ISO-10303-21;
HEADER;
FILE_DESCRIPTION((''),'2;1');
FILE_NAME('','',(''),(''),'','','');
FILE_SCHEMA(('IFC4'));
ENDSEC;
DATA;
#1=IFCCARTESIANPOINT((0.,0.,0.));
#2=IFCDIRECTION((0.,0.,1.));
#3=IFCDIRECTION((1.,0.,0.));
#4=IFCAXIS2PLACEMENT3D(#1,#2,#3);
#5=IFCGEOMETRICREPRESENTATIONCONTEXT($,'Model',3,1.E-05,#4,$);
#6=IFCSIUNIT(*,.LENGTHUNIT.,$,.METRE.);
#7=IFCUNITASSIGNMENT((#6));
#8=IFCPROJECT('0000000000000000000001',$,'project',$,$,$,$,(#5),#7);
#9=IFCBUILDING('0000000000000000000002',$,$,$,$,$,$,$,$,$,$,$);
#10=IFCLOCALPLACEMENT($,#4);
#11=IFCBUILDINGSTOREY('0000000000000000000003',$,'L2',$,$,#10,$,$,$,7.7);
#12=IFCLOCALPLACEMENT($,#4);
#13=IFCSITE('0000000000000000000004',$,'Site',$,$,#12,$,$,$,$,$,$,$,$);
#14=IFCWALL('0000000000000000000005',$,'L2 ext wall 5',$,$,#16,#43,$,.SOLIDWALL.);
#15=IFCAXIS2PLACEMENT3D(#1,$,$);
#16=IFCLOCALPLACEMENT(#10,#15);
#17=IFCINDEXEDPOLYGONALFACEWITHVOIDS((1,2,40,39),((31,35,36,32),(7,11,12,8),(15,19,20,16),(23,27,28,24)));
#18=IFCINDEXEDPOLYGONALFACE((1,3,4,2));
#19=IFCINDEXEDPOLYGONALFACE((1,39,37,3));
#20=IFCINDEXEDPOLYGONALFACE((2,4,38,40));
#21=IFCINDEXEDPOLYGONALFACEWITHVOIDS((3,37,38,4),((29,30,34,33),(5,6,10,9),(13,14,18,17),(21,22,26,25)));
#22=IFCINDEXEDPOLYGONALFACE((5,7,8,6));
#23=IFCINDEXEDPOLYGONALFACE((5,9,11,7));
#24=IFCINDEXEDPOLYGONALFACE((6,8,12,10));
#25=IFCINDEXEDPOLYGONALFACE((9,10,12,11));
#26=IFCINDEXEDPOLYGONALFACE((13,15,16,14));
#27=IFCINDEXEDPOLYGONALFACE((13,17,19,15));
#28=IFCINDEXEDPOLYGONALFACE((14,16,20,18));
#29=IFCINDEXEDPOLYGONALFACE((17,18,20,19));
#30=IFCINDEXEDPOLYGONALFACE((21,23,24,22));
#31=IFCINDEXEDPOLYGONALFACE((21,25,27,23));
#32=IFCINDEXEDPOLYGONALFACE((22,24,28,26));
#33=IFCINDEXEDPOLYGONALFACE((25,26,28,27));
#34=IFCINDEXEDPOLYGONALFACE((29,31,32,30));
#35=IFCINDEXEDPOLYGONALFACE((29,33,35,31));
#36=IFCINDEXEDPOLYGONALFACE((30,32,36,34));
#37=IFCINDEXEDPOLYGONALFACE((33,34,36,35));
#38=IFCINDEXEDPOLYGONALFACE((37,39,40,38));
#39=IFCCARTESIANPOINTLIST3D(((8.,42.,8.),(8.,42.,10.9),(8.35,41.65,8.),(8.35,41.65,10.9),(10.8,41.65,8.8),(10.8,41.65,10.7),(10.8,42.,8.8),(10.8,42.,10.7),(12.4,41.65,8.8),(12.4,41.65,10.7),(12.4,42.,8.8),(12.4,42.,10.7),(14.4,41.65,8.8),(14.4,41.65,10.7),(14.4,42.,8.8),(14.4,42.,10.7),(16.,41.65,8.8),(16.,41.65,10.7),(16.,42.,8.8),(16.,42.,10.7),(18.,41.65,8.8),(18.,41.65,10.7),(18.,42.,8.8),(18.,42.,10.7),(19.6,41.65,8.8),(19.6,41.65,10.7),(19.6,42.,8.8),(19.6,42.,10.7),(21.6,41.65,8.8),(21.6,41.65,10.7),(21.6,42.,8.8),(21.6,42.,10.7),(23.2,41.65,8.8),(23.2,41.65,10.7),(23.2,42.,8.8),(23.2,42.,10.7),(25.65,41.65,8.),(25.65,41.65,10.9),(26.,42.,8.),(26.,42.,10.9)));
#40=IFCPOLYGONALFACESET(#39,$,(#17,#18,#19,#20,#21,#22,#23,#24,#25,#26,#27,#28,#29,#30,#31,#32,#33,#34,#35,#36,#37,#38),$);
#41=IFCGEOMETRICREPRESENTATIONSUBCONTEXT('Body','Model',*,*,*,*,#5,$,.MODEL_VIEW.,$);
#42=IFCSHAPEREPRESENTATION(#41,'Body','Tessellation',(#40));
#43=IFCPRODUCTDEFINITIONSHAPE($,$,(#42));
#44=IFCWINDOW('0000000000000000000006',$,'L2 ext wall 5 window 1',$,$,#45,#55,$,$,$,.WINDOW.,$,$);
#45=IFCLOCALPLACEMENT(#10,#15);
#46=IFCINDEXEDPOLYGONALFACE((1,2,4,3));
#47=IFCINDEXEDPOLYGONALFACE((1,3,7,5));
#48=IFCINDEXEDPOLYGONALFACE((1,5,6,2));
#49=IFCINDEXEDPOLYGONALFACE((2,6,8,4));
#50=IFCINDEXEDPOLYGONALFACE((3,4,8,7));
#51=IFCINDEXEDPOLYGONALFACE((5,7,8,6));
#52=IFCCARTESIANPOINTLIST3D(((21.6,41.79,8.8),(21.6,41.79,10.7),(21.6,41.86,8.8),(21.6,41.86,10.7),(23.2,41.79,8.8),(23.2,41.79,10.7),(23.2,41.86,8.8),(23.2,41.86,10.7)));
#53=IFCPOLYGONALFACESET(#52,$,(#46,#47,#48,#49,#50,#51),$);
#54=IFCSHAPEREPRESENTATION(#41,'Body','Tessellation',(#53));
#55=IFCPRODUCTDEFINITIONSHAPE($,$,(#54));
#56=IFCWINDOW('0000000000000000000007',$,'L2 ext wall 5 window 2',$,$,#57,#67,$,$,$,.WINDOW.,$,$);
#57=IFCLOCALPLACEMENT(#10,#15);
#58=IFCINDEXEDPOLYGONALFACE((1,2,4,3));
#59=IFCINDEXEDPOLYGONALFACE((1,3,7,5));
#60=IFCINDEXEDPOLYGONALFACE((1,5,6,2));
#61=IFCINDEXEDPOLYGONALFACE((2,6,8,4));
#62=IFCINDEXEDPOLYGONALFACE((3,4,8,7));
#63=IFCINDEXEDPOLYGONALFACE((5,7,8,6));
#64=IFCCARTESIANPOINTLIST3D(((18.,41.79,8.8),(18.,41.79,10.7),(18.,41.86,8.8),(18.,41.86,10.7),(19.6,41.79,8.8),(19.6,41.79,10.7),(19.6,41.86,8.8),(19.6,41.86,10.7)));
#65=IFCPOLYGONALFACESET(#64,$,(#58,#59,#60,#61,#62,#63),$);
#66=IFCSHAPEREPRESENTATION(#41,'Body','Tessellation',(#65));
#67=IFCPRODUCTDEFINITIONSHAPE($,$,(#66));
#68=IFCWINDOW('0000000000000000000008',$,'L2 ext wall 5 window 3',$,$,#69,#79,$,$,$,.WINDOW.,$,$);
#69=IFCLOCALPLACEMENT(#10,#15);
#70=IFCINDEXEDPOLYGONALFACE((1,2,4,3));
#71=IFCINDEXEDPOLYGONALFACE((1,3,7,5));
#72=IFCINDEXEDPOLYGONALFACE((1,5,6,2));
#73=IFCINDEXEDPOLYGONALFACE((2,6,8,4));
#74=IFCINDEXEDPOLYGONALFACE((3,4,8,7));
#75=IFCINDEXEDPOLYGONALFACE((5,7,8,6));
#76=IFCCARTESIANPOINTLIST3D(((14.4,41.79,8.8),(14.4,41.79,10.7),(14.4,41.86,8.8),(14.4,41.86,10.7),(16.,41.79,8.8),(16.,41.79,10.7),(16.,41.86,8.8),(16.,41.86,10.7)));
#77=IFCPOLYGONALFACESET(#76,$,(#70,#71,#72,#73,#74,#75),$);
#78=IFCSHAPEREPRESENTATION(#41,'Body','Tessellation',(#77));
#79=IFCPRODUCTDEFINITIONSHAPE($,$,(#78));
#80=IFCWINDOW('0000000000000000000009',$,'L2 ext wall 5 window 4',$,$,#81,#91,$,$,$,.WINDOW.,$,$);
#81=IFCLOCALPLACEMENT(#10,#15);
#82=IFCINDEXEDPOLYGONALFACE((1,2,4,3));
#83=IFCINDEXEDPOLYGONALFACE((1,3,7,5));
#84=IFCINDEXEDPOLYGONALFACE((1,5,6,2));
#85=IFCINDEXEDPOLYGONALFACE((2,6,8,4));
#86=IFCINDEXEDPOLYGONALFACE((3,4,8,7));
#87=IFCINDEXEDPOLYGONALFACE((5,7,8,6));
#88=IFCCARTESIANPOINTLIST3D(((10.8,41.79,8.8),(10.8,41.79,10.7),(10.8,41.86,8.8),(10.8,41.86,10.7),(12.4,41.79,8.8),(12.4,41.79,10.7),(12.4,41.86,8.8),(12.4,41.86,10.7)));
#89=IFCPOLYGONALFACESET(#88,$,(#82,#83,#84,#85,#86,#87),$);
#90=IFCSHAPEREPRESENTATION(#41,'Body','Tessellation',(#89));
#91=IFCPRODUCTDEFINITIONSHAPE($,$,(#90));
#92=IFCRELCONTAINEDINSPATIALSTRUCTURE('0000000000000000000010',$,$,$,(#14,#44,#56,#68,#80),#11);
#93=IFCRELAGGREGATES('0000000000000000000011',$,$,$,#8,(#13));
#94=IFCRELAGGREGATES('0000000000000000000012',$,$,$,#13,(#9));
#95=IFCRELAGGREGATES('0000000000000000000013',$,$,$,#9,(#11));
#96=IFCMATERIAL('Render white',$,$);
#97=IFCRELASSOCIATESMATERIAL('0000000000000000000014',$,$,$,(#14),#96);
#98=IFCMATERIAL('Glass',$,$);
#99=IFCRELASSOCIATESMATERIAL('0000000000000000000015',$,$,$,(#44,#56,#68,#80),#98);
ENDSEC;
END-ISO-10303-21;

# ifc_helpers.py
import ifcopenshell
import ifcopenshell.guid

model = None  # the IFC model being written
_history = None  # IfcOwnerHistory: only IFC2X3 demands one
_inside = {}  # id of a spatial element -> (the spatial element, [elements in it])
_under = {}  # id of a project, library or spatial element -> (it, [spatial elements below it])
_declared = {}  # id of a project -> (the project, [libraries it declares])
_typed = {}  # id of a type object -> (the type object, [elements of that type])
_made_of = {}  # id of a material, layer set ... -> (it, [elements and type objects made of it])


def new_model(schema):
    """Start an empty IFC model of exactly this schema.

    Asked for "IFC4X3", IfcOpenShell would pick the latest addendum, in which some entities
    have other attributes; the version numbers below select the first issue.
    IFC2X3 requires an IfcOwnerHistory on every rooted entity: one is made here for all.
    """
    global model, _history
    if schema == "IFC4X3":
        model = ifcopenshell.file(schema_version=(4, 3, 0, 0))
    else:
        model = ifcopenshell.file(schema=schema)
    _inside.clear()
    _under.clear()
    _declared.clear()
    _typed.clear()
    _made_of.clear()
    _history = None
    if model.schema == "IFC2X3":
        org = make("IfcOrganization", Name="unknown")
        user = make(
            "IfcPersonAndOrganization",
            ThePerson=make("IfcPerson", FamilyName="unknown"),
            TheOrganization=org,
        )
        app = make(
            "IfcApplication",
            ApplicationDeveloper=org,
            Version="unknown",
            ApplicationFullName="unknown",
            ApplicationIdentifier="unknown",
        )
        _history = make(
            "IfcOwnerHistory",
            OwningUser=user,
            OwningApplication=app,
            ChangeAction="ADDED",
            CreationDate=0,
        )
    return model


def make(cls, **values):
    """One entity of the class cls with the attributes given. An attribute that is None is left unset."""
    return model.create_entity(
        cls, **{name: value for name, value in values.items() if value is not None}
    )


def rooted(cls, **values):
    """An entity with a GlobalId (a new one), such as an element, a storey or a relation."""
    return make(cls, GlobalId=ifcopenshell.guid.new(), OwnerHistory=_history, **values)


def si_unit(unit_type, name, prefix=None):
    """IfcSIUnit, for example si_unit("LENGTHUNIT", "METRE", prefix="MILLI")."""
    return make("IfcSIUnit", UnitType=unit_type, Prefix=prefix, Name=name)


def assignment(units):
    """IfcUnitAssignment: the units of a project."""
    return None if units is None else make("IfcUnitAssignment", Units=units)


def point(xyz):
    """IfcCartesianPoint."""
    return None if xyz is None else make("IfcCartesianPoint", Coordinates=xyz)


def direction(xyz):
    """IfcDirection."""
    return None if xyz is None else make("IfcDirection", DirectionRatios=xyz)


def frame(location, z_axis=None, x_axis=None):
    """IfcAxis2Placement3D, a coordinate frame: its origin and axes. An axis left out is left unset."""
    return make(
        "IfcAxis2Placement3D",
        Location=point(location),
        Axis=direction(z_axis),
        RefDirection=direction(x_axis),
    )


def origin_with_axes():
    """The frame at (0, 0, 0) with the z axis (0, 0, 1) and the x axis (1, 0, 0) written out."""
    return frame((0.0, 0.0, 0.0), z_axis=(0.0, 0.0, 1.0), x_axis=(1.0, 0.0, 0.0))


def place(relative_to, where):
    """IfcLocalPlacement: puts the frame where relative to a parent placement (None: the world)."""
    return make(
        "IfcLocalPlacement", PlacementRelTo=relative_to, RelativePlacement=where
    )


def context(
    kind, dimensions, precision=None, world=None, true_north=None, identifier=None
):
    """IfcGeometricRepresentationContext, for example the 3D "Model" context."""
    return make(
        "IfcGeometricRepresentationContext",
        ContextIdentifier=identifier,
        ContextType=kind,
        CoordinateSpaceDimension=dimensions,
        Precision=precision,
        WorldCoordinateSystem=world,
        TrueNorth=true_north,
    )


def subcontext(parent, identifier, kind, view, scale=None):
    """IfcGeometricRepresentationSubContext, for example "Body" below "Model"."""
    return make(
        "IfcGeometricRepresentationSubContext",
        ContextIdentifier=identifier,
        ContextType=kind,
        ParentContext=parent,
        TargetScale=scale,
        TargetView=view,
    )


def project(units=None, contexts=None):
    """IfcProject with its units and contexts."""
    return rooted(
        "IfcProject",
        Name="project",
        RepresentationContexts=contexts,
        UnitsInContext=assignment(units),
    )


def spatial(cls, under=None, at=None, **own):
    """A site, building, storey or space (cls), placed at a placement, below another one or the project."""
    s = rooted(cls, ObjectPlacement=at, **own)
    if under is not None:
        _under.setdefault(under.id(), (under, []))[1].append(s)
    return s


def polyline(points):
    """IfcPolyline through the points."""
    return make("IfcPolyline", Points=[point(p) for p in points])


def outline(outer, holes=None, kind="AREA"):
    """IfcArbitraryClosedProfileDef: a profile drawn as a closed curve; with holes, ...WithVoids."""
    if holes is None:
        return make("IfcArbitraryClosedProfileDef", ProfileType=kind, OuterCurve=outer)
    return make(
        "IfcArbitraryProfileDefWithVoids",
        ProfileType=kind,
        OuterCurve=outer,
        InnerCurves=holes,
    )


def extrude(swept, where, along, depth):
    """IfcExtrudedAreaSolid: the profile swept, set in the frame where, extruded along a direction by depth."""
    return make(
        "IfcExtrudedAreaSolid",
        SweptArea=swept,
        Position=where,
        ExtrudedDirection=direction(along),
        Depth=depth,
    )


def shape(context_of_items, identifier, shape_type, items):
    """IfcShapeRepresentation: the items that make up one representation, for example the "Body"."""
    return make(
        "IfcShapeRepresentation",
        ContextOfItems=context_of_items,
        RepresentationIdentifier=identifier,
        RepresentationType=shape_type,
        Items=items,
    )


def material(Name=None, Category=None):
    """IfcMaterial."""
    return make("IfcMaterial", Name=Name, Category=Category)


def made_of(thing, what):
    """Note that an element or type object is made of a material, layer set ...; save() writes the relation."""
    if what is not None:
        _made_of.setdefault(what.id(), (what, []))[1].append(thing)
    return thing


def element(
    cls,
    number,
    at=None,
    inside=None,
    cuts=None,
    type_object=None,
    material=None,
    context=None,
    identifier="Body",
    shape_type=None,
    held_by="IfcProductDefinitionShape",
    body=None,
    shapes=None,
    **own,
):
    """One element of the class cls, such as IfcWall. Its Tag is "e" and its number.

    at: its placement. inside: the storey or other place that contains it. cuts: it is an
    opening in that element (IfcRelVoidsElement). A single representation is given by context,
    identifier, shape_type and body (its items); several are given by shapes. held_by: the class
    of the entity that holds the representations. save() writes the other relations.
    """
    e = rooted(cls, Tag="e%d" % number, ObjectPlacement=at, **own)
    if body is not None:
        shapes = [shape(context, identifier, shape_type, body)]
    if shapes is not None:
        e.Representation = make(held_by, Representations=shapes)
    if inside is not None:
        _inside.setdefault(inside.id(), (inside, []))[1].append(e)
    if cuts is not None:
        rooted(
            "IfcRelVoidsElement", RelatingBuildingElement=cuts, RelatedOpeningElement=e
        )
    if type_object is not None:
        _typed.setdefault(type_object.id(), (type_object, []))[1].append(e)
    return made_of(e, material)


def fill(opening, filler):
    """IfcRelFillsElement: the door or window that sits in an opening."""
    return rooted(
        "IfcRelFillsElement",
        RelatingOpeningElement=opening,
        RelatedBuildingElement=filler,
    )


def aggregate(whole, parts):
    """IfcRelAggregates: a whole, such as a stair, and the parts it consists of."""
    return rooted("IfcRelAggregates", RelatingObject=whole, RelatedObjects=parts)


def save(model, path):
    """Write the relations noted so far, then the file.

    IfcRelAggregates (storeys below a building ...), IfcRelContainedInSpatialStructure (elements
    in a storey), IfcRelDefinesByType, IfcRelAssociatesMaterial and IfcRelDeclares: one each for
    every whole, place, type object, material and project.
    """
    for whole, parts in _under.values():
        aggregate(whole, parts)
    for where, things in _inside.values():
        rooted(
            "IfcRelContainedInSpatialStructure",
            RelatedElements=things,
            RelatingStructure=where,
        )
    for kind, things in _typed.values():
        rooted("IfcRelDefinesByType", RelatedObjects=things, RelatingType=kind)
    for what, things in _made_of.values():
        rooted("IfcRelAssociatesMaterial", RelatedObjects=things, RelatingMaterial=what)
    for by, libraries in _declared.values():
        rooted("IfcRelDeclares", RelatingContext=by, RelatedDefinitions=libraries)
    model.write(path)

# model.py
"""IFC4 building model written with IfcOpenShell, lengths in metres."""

from ifc_helpers import new_model, si_unit, frame, origin_with_axes, place, context, subcontext, project, spatial, polyline, outline, extrude, material, element, fill, save


model = new_model("IFC4")

# Units and contexts
model_context = context("Model", 3, precision=1e-05, world=origin_with_axes())
body_context = subcontext(model_context, "Body", "Model", "MODEL_VIEW")
ifc_project = project(units=[si_unit("LENGTHUNIT", "METRE")], contexts=[model_context])

# Site, building, storey
site_placement = place(None, origin_with_axes())
site = spatial("IfcSite", under=ifc_project, at=site_placement, Name="Site")
building = spatial("IfcBuilding", under=site)
storey_placement = place(None, origin_with_axes())
storey = spatial("IfcBuildingStorey", under=building, at=storey_placement, Name="L2", Elevation=7.7)

# Wall, openings, windows
ifc_material_1 = material(Name="Render white")
wall_1_placement = place(storey_placement, origin_with_axes())
wall_1 = element("IfcWall", 1, at=wall_1_placement, inside=storey, material=ifc_material_1, Name="L2 ext wall 5", PredefinedType="SOLIDWALL", context=body_context, shape_type="SweptSolid", body=[
    extrude(outline(polyline([(26.0, 42.0), (8.0, 42.0), (8.35, 41.65), (25.65, 41.65), (26.0, 42.0)])), frame((0.0, 0.0, 8.0), z_axis=(0.0, 0.0, 1.0), x_axis=(1.0, 0.0, 0.0)), (0.0, 0.0, 1.0), 2.9),
])
opening_1_placement = place(wall_1_placement, origin_with_axes())
opening_1 = element("IfcOpeningElement", 2, at=opening_1_placement, cuts=wall_1, context=body_context, shape_type="SweptSolid", body=[
    extrude(outline(polyline([(23.2, 42.05), (21.6, 42.05), (21.6, 41.6), (23.2, 41.6), (23.2, 42.05)])), frame((0.0, 0.0, 8.8), z_axis=(0.0, 0.0, 1.0), x_axis=(1.0, 0.0, 0.0)), (0.0, 0.0, 1.0), 1.9),
])
opening_2_placement = place(wall_1_placement, origin_with_axes())
opening_2 = element("IfcOpeningElement", 3, at=opening_2_placement, cuts=wall_1, context=body_context, shape_type="SweptSolid", body=[
    extrude(outline(polyline([(19.6, 42.05), (18.0, 42.05), (18.0, 41.6), (19.6, 41.6), (19.6, 42.05)])), frame((0.0, 0.0, 8.8), z_axis=(0.0, 0.0, 1.0), x_axis=(1.0, 0.0, 0.0)), (0.0, 0.0, 1.0), 1.9),
])
opening_3_placement = place(wall_1_placement, origin_with_axes())
opening_3 = element("IfcOpeningElement", 4, at=opening_3_placement, cuts=wall_1, context=body_context, shape_type="SweptSolid", body=[
    extrude(outline(polyline([(16.0, 42.05), (14.4, 42.05), (14.4, 41.6), (16.0, 41.6), (16.0, 42.05)])), frame((0.0, 0.0, 8.8), z_axis=(0.0, 0.0, 1.0), x_axis=(1.0, 0.0, 0.0)), (0.0, 0.0, 1.0), 1.9),
])
opening_4_placement = place(wall_1_placement, origin_with_axes())
opening_4 = element("IfcOpeningElement", 5, at=opening_4_placement, cuts=wall_1, context=body_context, shape_type="SweptSolid", body=[
    extrude(outline(polyline([(12.4, 42.05), (10.8, 42.05), (10.8, 41.6), (12.4, 41.6), (12.4, 42.05)])), frame((0.0, 0.0, 8.8), z_axis=(0.0, 0.0, 1.0), x_axis=(1.0, 0.0, 0.0)), (0.0, 0.0, 1.0), 1.9),
])
ifc_material_2 = material(Name="Glass")
window_1_placement = place(storey_placement, origin_with_axes())
window_1 = element("IfcWindow", 6, at=window_1_placement, inside=storey, material=ifc_material_2, Name="L2 ext wall 5 window 1", PredefinedType="WINDOW", context=body_context, shape_type="SweptSolid", body=[
    extrude(outline(polyline([(23.2, 41.86), (21.6, 41.86), (21.6, 41.79), (23.2, 41.79), (23.2, 41.86)])), frame((0.0, 0.0, 8.8), z_axis=(0.0, 0.0, 1.0), x_axis=(1.0, 0.0, 0.0)), (0.0, 0.0, 1.0), 1.9),
])
fill(opening_1, window_1)
window_2_placement = place(storey_placement, origin_with_axes())
window_2 = element("IfcWindow", 7, at=window_2_placement, inside=storey, material=ifc_material_2, Name="L2 ext wall 5 window 2", PredefinedType="WINDOW", context=body_context, shape_type="SweptSolid", body=[
    extrude(outline(polyline([(19.6, 41.86), (18.0, 41.86), (18.0, 41.79), (19.6, 41.79), (19.6, 41.86)])), frame((0.0, 0.0, 8.8), z_axis=(0.0, 0.0, 1.0), x_axis=(1.0, 0.0, 0.0)), (0.0, 0.0, 1.0), 1.9),
])
fill(opening_2, window_2)
window_3_placement = place(storey_placement, origin_with_axes())
window_3 = element("IfcWindow", 8, at=window_3_placement, inside=storey, material=ifc_material_2, Name="L2 ext wall 5 window 3", PredefinedType="WINDOW", context=body_context, shape_type="SweptSolid", body=[
    extrude(outline(polyline([(16.0, 41.86), (14.4, 41.86), (14.4, 41.79), (16.0, 41.79), (16.0, 41.86)])), frame((0.0, 0.0, 8.8), z_axis=(0.0, 0.0, 1.0), x_axis=(1.0, 0.0, 0.0)), (0.0, 0.0, 1.0), 1.9),
])
fill(opening_3, window_3)
window_4_placement = place(storey_placement, origin_with_axes())
window_4 = element("IfcWindow", 9, at=window_4_placement, inside=storey, material=ifc_material_2, Name="L2 ext wall 5 window 4", PredefinedType="WINDOW", context=body_context, shape_type="SweptSolid", body=[
    extrude(outline(polyline([(12.4, 41.86), (10.8, 41.86), (10.8, 41.79), (12.4, 41.79), (12.4, 41.86)])), frame((0.0, 0.0, 8.8), z_axis=(0.0, 0.0, 1.0), x_axis=(1.0, 0.0, 0.0)), (0.0, 0.0, 1.0), 1.9),
])
fill(opening_4, window_4)

save(model, "model.ifc")
